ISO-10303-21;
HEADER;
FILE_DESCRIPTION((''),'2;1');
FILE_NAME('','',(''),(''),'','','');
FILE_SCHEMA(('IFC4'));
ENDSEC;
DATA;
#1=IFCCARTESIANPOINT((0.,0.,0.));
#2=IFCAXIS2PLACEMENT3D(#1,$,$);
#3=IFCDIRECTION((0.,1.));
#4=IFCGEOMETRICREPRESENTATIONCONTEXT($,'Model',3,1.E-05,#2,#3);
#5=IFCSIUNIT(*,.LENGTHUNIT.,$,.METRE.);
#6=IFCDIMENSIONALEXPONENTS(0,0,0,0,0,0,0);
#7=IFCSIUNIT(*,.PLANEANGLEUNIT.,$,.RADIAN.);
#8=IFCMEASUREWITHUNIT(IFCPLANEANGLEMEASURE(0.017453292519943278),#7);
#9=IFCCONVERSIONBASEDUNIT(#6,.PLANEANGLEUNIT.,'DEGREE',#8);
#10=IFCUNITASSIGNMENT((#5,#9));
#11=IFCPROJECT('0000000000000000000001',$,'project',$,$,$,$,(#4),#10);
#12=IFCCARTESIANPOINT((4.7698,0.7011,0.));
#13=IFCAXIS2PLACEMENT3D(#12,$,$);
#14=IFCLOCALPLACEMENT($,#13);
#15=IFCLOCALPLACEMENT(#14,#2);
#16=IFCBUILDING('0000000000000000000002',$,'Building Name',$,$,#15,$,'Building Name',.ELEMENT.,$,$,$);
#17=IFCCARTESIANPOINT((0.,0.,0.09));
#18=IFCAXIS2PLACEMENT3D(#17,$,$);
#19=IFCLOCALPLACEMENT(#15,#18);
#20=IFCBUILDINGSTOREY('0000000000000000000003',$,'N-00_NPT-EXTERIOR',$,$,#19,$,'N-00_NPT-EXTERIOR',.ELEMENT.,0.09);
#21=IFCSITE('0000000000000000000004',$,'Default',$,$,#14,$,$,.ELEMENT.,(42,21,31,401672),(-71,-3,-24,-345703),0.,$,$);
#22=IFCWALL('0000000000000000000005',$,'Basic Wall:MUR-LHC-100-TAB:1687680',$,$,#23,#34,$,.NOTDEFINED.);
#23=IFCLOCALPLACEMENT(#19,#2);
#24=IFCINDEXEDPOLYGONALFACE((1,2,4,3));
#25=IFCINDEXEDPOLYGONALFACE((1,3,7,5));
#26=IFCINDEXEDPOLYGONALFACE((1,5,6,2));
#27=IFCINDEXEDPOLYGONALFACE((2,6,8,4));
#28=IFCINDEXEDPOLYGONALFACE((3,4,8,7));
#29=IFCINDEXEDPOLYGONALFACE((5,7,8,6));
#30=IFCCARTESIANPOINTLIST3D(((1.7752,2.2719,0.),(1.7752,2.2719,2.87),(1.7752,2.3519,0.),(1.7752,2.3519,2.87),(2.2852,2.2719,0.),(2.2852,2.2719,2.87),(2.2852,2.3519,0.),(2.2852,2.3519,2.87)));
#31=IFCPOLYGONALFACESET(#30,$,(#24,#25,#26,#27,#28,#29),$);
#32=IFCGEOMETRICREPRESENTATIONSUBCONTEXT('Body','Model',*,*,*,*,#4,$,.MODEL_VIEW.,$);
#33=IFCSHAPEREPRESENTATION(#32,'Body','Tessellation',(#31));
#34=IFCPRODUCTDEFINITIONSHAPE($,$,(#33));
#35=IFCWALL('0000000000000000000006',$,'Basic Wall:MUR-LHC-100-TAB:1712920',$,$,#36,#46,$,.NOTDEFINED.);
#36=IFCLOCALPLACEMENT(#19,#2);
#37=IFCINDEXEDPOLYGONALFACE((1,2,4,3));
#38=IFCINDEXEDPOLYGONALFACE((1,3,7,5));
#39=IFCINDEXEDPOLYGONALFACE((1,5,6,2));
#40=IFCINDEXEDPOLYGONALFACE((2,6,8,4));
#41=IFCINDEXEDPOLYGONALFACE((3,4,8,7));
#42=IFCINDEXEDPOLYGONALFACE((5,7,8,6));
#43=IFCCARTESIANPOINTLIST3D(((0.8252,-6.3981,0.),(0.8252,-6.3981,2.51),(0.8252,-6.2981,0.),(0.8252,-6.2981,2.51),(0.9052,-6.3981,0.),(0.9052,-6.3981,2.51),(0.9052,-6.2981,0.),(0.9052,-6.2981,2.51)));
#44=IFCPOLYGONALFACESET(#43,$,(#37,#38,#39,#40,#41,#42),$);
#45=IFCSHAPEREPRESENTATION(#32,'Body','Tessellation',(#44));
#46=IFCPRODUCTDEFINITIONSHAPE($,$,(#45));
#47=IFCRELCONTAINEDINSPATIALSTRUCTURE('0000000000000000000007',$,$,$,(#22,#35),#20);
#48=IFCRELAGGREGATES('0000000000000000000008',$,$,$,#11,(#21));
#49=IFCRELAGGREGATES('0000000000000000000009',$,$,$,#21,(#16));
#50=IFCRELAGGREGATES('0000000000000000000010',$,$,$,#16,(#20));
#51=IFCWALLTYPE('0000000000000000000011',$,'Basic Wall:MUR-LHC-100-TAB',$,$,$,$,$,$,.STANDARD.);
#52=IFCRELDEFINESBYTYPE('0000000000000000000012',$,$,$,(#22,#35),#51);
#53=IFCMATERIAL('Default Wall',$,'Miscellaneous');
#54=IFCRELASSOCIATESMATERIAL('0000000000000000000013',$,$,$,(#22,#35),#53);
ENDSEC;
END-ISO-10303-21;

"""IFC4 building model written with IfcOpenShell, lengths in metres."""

from ifc_helpers import new_model, entity, si_unit, converted_unit, direction, frame, origin, place, context, subcontext, project, spatial, indexed_curve, outline, extrude, material, type_object, element, save


model = new_model("IFC4")

# Units and contexts
model_context = context("Model", 3, precision=1e-05, world=origin(), true_north=direction((0.0, 1.0)))
body_context = subcontext(model_context, "Body", "Model", "MODEL_VIEW")
ifc_project = project(units=[si_unit("LENGTHUNIT", "METRE"), converted_unit("PLANEANGLEUNIT", "DEGREE", entity("IfcPlaneAngleMeasure", 0.017453292519943278), si_unit("PLANEANGLEUNIT", "RADIAN"), dimensions=[0, 0, 0, 0, 0, 0, 0])], contexts=[model_context])

# Site, building, storey
site_placement = place(None, frame((4.7698, 0.7011, 0.0)))
site = spatial("IfcSite", under=ifc_project, at=site_placement, Name="Default", CompositionType="ELEMENT", RefLatitude=(42, 21, 31, 401672), RefLongitude=(-71, -3, -24, -345703), RefElevation=0.0)
building_placement = place(site_placement, origin())
building = spatial("IfcBuilding", under=site, at=building_placement, Name="Building Name", LongName="Building Name", CompositionType="ELEMENT")
storey_placement = place(building_placement, frame((0.0, 0.0, 0.09)))
storey = spatial("IfcBuildingStorey", under=building, at=storey_placement, Name="N-00_NPT-EXTERIOR", LongName="N-00_NPT-EXTERIOR", CompositionType="ELEMENT", Elevation=0.09)

# Walls
ifc_material_1 = material(Name="Default Wall", Category="Miscellaneous")
wall_type_1 = type_object("IfcWallType", Name="Basic Wall:MUR-LHC-100-TAB", PredefinedType="STANDARD")
wall_1_placement = place(storey_placement, frame((1.7752, 2.3119, 0.0)))
element("IfcWall", 1, at=wall_1_placement, inside=storey, type_object=wall_type_1, material=ifc_material_1, Name="Basic Wall:MUR-LHC-100-TAB:1687680", PredefinedType="NOTDEFINED", context=body_context, shape_type="SweptSolid", body=[
    extrude(outline(indexed_curve([(0.51, 0.04), (0.0, 0.04), (0.0, -0.04), (0.51, -0.04), (0.51, 0.04)], self_intersect=False)), origin(), (0.0, 0.0, 1.0), 2.87),
])
wall_2_placement = place(storey_placement, frame((0.8652, -6.2981, 0.0), z_axis=(0.0, 0.0, 1.0), x_axis=(0.0, -1.0, 0.0)))
element("IfcWall", 2, at=wall_2_placement, inside=storey, type_object=wall_type_1, material=ifc_material_1, Name="Basic Wall:MUR-LHC-100-TAB:1712920", PredefinedType="NOTDEFINED", context=body_context, shape_type="SweptSolid", body=[
    extrude(outline(indexed_curve([(0.1, 0.04), (0.0, 0.04), (0.0, -0.04), (0.1, -0.04), (0.1, 0.04)], self_intersect=False)), origin(), (0.0, 0.0, 1.0), 2.51),
])

save(model, "model.ifc")
